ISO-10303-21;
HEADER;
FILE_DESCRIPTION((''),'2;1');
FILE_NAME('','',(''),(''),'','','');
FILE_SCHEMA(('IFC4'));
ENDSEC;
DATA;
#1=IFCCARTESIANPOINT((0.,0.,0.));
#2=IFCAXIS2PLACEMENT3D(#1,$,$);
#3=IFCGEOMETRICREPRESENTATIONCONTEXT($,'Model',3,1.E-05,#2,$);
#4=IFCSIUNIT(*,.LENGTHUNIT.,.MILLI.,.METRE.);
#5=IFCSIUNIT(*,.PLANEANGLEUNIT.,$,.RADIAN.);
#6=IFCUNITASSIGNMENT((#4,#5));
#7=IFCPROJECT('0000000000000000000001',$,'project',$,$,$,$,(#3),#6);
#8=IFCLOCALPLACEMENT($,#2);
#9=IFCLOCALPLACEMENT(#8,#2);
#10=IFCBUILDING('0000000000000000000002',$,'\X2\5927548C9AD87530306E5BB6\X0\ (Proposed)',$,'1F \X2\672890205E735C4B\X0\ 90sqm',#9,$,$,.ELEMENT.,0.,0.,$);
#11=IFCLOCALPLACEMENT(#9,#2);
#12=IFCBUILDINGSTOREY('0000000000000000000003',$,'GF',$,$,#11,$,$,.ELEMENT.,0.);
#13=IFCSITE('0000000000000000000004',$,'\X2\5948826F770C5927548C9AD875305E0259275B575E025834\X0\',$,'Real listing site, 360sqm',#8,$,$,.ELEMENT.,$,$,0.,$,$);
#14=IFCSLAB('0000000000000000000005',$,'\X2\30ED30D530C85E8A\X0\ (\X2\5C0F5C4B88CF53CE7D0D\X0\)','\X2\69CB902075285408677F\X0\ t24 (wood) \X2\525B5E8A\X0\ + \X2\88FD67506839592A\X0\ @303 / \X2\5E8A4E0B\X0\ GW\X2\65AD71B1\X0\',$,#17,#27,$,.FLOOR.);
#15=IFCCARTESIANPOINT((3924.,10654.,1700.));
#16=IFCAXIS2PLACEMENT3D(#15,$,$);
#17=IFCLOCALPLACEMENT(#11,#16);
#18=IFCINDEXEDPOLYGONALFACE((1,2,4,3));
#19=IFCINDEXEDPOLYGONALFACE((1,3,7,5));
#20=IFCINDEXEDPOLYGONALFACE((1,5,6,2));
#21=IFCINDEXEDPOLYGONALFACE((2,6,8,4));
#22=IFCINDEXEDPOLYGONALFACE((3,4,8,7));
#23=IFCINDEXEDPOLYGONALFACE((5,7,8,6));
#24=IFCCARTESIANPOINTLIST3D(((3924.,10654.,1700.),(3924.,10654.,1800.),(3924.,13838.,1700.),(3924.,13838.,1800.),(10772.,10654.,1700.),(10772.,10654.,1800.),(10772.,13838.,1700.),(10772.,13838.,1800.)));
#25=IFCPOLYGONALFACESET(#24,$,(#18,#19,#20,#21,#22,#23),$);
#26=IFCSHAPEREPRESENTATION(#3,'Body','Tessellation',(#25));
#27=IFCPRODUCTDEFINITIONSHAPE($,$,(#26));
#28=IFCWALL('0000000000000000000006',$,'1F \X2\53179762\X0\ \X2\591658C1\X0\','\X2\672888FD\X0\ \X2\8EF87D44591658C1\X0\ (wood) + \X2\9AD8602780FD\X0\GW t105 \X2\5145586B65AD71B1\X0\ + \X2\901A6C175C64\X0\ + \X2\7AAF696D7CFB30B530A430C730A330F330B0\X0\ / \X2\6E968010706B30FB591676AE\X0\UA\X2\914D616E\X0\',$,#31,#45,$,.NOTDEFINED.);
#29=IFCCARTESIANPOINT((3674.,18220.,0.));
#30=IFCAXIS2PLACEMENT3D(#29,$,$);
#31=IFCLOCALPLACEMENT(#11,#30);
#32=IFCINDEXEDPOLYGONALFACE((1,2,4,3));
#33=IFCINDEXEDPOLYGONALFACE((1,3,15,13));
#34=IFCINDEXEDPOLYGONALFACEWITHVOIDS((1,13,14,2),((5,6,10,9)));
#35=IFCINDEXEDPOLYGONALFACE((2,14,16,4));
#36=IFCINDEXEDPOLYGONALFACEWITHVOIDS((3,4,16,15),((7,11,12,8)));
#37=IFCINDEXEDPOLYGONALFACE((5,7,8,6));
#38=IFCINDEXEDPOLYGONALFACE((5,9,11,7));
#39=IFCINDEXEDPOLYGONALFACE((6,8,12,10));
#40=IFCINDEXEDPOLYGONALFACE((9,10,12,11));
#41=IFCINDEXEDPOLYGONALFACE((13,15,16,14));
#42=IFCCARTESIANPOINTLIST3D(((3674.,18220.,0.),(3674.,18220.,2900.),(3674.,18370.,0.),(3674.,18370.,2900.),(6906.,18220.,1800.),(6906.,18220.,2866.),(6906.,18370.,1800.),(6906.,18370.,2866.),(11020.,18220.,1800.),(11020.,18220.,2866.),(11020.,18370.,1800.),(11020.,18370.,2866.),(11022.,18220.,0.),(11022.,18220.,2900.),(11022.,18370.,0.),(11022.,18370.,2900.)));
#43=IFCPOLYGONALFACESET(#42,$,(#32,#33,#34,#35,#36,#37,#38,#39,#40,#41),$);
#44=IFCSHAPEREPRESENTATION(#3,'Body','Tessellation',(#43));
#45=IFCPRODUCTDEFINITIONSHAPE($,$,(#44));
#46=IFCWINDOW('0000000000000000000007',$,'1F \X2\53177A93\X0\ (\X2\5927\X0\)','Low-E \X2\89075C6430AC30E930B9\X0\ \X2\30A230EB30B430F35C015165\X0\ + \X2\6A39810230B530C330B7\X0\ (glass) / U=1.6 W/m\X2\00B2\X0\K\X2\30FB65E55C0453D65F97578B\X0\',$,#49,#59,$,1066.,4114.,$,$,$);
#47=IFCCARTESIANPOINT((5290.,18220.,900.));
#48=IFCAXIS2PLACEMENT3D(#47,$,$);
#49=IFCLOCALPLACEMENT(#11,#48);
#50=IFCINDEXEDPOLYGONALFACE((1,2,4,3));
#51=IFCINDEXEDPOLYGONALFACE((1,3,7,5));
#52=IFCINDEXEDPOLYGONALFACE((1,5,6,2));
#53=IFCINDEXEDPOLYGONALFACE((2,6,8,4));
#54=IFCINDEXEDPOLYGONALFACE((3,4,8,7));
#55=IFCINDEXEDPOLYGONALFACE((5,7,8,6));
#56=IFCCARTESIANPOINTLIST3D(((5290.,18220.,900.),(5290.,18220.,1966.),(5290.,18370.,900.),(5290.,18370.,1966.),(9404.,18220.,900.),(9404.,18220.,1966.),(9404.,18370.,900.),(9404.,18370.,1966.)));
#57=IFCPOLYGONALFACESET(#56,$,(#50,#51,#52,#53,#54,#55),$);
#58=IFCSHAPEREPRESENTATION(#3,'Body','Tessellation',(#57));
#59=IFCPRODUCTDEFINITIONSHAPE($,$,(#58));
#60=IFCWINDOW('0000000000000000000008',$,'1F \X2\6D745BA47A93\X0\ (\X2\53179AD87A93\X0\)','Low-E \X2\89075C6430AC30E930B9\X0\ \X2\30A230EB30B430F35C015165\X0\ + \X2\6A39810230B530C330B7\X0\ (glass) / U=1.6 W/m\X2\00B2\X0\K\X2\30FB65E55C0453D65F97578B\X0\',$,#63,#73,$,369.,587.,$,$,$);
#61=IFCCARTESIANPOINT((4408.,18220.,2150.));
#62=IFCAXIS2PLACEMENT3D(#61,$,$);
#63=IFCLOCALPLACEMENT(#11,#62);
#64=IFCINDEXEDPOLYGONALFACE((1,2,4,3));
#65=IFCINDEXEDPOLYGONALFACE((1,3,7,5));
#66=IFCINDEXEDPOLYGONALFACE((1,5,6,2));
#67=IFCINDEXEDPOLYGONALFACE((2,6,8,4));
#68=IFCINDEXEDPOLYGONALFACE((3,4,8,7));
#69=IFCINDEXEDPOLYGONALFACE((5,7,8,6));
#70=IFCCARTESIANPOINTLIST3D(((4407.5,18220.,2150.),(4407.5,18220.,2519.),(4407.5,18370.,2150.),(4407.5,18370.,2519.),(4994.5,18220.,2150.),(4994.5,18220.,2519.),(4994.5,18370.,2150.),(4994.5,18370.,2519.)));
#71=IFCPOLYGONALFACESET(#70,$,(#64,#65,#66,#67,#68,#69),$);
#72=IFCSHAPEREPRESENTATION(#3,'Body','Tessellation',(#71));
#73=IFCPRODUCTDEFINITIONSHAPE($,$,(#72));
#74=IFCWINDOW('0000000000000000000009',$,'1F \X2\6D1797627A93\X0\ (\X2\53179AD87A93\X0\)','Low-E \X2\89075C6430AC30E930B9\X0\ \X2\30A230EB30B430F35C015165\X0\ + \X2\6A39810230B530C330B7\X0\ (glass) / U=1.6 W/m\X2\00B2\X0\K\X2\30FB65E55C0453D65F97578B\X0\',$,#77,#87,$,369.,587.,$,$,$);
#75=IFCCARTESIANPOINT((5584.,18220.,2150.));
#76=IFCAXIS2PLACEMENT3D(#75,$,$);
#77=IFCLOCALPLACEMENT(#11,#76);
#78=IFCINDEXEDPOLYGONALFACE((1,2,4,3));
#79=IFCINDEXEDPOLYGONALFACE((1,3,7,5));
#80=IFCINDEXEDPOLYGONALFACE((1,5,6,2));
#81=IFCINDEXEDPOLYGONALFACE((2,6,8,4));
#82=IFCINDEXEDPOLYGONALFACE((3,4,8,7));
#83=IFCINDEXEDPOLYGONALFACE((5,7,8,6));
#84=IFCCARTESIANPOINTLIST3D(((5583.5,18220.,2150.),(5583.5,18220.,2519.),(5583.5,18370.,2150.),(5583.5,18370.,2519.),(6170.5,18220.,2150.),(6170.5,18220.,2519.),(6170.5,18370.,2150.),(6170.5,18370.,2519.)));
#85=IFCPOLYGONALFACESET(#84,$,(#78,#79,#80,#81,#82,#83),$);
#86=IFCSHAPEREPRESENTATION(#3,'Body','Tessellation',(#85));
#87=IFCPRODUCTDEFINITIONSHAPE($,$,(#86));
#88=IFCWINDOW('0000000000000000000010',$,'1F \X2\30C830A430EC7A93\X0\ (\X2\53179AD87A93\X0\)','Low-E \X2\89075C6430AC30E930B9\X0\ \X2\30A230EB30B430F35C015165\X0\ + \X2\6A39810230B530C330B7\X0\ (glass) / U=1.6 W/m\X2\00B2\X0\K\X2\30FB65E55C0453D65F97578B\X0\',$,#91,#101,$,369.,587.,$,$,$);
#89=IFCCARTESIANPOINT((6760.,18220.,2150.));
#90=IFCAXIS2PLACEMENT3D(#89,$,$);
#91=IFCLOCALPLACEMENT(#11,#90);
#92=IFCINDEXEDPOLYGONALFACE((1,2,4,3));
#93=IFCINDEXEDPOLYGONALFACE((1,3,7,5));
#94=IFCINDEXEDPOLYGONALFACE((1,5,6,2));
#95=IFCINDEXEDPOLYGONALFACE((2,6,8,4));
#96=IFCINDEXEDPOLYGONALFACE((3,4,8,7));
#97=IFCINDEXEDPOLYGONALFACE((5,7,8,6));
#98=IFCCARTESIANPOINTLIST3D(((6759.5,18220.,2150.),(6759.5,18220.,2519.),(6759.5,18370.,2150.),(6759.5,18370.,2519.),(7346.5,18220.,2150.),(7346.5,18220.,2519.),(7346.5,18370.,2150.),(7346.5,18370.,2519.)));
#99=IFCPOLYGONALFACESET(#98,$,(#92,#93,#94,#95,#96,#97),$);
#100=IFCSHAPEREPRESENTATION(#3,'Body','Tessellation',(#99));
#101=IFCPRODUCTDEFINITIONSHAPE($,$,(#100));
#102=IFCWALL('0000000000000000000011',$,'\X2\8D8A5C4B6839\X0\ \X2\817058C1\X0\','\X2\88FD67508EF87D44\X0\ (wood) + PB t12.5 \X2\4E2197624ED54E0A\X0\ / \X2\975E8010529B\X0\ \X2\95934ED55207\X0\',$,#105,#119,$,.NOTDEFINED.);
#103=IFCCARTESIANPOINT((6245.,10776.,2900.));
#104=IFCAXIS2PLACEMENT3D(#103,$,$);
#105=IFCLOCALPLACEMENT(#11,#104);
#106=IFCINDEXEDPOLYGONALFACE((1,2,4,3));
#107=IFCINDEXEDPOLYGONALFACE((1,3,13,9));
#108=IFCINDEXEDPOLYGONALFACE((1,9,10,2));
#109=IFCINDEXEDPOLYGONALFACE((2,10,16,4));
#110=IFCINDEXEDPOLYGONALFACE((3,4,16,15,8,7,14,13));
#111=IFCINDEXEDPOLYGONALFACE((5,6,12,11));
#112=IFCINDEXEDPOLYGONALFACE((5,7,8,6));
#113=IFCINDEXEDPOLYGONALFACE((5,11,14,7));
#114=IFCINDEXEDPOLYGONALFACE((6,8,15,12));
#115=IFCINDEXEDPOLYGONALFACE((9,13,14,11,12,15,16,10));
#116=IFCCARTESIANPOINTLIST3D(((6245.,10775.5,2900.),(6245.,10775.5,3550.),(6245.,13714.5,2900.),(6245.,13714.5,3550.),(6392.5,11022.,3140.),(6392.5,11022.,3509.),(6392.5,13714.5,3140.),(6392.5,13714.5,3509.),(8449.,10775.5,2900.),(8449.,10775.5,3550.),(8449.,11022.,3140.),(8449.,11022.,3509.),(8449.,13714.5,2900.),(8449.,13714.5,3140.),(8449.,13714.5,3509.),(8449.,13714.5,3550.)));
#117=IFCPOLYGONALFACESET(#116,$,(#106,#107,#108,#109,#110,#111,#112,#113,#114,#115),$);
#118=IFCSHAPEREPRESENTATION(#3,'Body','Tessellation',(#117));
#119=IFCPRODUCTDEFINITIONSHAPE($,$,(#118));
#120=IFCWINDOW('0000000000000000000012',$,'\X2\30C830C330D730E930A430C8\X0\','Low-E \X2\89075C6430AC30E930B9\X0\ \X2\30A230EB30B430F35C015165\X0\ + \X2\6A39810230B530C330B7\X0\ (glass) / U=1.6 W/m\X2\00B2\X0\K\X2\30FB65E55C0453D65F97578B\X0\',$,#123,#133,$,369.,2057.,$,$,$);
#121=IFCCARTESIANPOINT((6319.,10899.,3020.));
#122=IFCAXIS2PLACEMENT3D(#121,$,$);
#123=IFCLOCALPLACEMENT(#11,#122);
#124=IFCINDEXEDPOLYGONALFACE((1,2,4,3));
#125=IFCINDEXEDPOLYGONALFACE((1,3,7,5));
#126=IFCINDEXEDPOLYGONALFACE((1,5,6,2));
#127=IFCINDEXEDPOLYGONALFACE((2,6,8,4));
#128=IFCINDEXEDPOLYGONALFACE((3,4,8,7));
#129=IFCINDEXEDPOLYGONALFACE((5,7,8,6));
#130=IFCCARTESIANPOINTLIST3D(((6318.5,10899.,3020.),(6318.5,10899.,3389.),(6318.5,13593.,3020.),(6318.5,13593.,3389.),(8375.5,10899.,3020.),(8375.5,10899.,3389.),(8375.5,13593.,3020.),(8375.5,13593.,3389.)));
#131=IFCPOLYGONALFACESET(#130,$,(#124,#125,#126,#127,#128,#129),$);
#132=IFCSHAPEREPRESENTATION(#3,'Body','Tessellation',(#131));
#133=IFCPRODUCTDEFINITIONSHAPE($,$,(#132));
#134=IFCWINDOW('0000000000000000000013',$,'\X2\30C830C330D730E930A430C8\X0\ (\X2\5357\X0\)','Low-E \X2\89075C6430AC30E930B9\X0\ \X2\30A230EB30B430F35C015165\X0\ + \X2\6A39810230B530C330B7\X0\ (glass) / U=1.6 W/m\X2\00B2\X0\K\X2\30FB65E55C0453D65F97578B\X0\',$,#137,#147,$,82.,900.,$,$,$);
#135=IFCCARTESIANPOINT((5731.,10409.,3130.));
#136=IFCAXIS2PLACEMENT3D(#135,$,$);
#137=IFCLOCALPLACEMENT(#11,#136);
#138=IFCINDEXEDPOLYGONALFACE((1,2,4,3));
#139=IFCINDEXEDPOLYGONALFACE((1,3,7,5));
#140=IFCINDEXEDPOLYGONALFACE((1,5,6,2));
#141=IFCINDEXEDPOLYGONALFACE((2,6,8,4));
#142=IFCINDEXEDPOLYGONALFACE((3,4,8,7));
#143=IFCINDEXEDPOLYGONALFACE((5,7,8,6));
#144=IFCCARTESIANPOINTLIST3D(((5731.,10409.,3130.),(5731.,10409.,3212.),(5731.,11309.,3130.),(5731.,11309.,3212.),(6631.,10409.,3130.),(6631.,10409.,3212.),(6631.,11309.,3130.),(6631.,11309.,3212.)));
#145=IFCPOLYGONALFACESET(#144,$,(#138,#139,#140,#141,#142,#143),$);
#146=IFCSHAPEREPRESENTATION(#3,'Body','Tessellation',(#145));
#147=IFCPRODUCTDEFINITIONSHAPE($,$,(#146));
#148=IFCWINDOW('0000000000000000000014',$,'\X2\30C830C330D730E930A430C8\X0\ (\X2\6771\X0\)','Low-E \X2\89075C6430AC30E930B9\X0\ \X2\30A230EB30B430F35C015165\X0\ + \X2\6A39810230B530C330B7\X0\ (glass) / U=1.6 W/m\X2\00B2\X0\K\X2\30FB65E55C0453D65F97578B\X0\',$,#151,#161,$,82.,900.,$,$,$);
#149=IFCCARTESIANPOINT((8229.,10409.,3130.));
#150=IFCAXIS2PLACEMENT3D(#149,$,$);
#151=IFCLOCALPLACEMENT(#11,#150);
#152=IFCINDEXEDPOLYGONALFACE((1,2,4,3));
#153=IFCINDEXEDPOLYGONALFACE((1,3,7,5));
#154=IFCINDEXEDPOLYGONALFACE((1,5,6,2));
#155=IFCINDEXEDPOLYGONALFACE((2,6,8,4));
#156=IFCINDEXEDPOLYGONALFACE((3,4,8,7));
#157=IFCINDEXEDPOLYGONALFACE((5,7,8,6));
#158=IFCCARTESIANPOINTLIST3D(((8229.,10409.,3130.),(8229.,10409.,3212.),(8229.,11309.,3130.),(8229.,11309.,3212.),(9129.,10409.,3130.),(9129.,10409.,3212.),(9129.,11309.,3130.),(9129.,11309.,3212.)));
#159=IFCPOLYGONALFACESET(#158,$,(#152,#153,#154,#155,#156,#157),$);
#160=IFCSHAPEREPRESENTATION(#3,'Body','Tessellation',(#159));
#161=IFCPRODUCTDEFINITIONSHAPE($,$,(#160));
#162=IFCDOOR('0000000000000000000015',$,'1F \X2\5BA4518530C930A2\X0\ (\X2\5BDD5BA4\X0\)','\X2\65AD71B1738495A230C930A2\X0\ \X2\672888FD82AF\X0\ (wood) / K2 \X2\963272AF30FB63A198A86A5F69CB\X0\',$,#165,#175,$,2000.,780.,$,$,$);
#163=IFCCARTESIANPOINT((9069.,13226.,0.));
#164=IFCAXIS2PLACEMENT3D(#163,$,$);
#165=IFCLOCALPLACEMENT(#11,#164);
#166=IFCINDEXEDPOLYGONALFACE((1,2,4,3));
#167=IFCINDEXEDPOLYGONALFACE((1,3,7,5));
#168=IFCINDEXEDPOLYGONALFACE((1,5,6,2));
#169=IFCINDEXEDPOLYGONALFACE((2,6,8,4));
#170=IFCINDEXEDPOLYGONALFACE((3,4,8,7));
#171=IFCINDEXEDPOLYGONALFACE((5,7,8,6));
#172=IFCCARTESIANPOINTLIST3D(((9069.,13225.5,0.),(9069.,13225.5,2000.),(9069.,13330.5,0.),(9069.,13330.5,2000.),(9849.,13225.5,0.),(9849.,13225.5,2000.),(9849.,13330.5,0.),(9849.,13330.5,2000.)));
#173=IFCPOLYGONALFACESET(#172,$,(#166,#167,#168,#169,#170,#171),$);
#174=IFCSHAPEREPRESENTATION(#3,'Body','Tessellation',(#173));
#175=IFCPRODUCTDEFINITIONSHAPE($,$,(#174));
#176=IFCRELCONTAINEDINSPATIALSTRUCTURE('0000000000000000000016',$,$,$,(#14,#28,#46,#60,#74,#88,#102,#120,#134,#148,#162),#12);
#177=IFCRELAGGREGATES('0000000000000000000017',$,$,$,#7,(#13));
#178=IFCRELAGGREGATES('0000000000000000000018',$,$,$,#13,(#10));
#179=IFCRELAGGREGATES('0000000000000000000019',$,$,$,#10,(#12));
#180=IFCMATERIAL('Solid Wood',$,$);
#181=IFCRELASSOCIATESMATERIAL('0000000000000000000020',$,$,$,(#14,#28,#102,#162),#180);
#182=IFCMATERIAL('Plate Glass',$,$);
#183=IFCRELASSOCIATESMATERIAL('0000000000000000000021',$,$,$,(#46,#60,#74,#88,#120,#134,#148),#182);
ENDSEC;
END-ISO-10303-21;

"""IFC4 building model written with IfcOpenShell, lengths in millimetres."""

from ifc_helpers import new_model, si_unit, frame, frame_2d, origin, place, context, project, spatial, rectangle, extrude, material, element, fill, save


model = new_model("IFC4")

# Units and contexts
model_context = context("Model", 3, precision=1e-05, world=origin())
ifc_project = project(units=[si_unit("LENGTHUNIT", "METRE", prefix="MILLI"), si_unit("PLANEANGLEUNIT", "RADIAN")], contexts=[model_context])

# Site, building, storey
site_placement = place(None, origin())
site = spatial("IfcSite", under=ifc_project, at=site_placement, Name="奈良県大和高田市大字市場", ObjectType="Real listing site, 360sqm", CompositionType="ELEMENT", RefElevation=0.0)
building_placement = place(site_placement, origin())
building = spatial("IfcBuilding", under=site, at=building_placement, Name="大和高田の家 (Proposed)", ObjectType="1F 木造平屋 90sqm", CompositionType="ELEMENT", ElevationOfRefHeight=0.0, ElevationOfTerrain=0.0)
storey_placement = place(building_placement, origin())
storey = spatial("IfcBuildingStorey", under=building, at=storey_placement, Name="GF", CompositionType="ELEMENT", Elevation=0.0)

# Slab
ifc_material_1 = material(Name="Solid Wood")
slab_placement = place(storey_placement, frame((3924.0, 10654.0, 1700.0)))
element("IfcSlab", 1, at=slab_placement, inside=storey, material=ifc_material_1, Name="ロフト床 (小屋裏収納)", Description="構造用合板 t24 (wood) 剛床 + 製材根太 @303 / 床下 GW断熱", PredefinedType="FLOOR", context=model_context, shape_type="SweptSolid", body=[
    extrude(rectangle(XDim=6848.0, YDim=3184.0, at=frame_2d((3424.0, 1592.0))), frame((3924.0, 10654.0, 1700.0)), (0.0, 0.0, 1.0), 100.0),
])

# Wall, openings, windows
wall_1_placement = place(storey_placement, frame((3674.0, 18220.0, 0.0)))
wall_1 = element("IfcWall", 2, at=wall_1_placement, inside=storey, material=ifc_material_1, Name="1F 北面 外壁", Description="木製 軸組外壁 (wood) + 高性能GW t105 充填断熱 + 通気層 + 窯業系サイディング / 準耐火・外皮UA配慮", PredefinedType="NOTDEFINED", context=model_context, shape_type="SweptSolid", body=[
    extrude(rectangle(XDim=7348.0, YDim=150.0, at=frame_2d((3674.0, 75.0))), frame((3674.0, 18220.0, 0.0)), (0.0, 0.0, 1.0), 2900.0),
])
opening_1_placement = place(storey_placement, frame((5290.0, 18220.0, 900.0)))
opening_1 = element("IfcOpeningElement", 3, at=opening_1_placement, cuts=wall_1, PredefinedType="NOTDEFINED", context=model_context, shape_type="SweptSolid", body=[
    extrude(rectangle(XDim=4114.0, YDim=150.0, at=frame_2d((2057.0, 75.0))), frame((5290.0, 18220.0, 900.0)), (0.0, 0.0, 1.0), 1066.0),
])
opening_2_placement = place(storey_placement, frame((4408.0, 18220.0, 2150.0)))
opening_2 = element("IfcOpeningElement", 4, at=opening_2_placement, cuts=wall_1, PredefinedType="NOTDEFINED", context=model_context, shape_type="SweptSolid", body=[
    extrude(rectangle(XDim=587.0, YDim=150.0, at=frame_2d((293.0, 75.0))), frame((4408.0, 18220.0, 2150.0)), (0.0, 0.0, 1.0), 369.0),
])
opening_3_placement = place(storey_placement, frame((5584.0, 18220.0, 2150.0)))
opening_3 = element("IfcOpeningElement", 5, at=opening_3_placement, cuts=wall_1, PredefinedType="NOTDEFINED", context=model_context, shape_type="SweptSolid", body=[
    extrude(rectangle(XDim=587.0, YDim=150.0, at=frame_2d((293.0, 75.0))), frame((5584.0, 18220.0, 2150.0)), (0.0, 0.0, 1.0), 369.0),
])
opening_4_placement = place(storey_placement, frame((6760.0, 18220.0, 2150.0)))
opening_4 = element("IfcOpeningElement", 6, at=opening_4_placement, cuts=wall_1, PredefinedType="NOTDEFINED", context=model_context, shape_type="SweptSolid", body=[
    extrude(rectangle(XDim=587.0, YDim=150.0, at=frame_2d((293.0, 75.0))), frame((6760.0, 18220.0, 2150.0)), (0.0, 0.0, 1.0), 369.0),
])
ifc_material_2 = material(Name="Plate Glass")
window_1_placement = place(storey_placement, frame((5290.0, 18220.0, 900.0)))
window_1 = element("IfcWindow", 7, at=window_1_placement, inside=storey, material=ifc_material_2, Name="1F 北窓 (大)", Description="Low-E 複層ガラス アルゴン封入 + 樹脂サッシ (glass) / U=1.6 W/m²K・日射取得型", OverallHeight=1066.0, OverallWidth=4114.0, context=model_context, shape_type="SweptSolid", body=[
    extrude(rectangle(XDim=4114.0, YDim=150.0, at=frame_2d((2057.0, 75.0))), frame((5290.0, 18220.0, 900.0)), (0.0, 0.0, 1.0), 1066.0),
])
fill(opening_1, window_1)
window_2_placement = place(storey_placement, frame((4408.0, 18220.0, 2150.0)))
window_2 = element("IfcWindow", 8, at=window_2_placement, inside=storey, material=ifc_material_2, Name="1F 浴室窓 (北高窓)", Description="Low-E 複層ガラス アルゴン封入 + 樹脂サッシ (glass) / U=1.6 W/m²K・日射取得型", OverallHeight=369.0, OverallWidth=587.0, context=model_context, shape_type="SweptSolid", body=[
    extrude(rectangle(XDim=587.0, YDim=150.0, at=frame_2d((293.0, 75.0))), frame((4408.0, 18220.0, 2150.0)), (0.0, 0.0, 1.0), 369.0),
])
fill(opening_2, window_2)
window_3_placement = place(storey_placement, frame((5584.0, 18220.0, 2150.0)))
window_3 = element("IfcWindow", 9, at=window_3_placement, inside=storey, material=ifc_material_2, Name="1F 洗面窓 (北高窓)", Description="Low-E 複層ガラス アルゴン封入 + 樹脂サッシ (glass) / U=1.6 W/m²K・日射取得型", OverallHeight=369.0, OverallWidth=587.0, context=model_context, shape_type="SweptSolid", body=[
    extrude(rectangle(XDim=587.0, YDim=150.0, at=frame_2d((293.0, 75.0))), frame((5584.0, 18220.0, 2150.0)), (0.0, 0.0, 1.0), 369.0),
])
fill(opening_3, window_3)
window_4_placement = place(storey_placement, frame((6760.0, 18220.0, 2150.0)))
window_4 = element("IfcWindow", 10, at=window_4_placement, inside=storey, material=ifc_material_2, Name="1F トイレ窓 (北高窓)", Description="Low-E 複層ガラス アルゴン封入 + 樹脂サッシ (glass) / U=1.6 W/m²K・日射取得型", OverallHeight=369.0, OverallWidth=587.0, context=model_context, shape_type="SweptSolid", body=[
    extrude(rectangle(XDim=587.0, YDim=150.0, at=frame_2d((293.0, 75.0))), frame((6760.0, 18220.0, 2150.0)), (0.0, 0.0, 1.0), 369.0),
])
fill(opening_4, window_4)

# Wall, openings, windows
wall_2_placement = place(storey_placement, frame((6245.0, 10776.0, 2900.0)))
wall_2 = element("IfcWall", 11, at=wall_2_placement, inside=storey, material=ifc_material_1, Name="越屋根 腰壁", Description="製材軸組 (wood) + PB t12.5 両面仕上 / 非耐力 間仕切", PredefinedType="NOTDEFINED", context=model_context, shape_type="SweptSolid", body=[
    extrude(rectangle(XDim=2204.0, YDim=2939.0, at=frame_2d((1102.0, 1469.0))), frame((6245.0, 10776.0, 2900.0)), (0.0, 0.0, 1.0), 650.0),
])
opening_5_placement = place(storey_placement, frame((6319.0, 10899.0, 3020.0)))
opening_5 = element("IfcOpeningElement", 12, at=opening_5_placement, cuts=wall_2, PredefinedType="NOTDEFINED", context=model_context, shape_type="SweptSolid", body=[
    extrude(rectangle(XDim=2057.0, YDim=2694.0, at=frame_2d((1028.0, 1347.0))), frame((6319.0, 10899.0, 3020.0)), (0.0, 0.0, 1.0), 369.0),
])
opening_6_placement = place(storey_placement, frame((5731.0, 10409.0, 3130.0)))
opening_6 = element("IfcOpeningElement", 13, at=opening_6_placement, cuts=wall_2, PredefinedType="NOTDEFINED", context=model_context, shape_type="SweptSolid", body=[
    extrude(rectangle(XDim=900.0, YDim=900.0, at=frame_2d((450.0, 450.0))), frame((5731.0, 10409.0, 3130.0)), (0.0, 0.0, 1.0), 82.0),
])
opening_7_placement = place(storey_placement, frame((8229.0, 10409.0, 3130.0)))
opening_7 = element("IfcOpeningElement", 14, at=opening_7_placement, cuts=wall_2, PredefinedType="NOTDEFINED", context=model_context, shape_type="SweptSolid", body=[
    extrude(rectangle(XDim=900.0, YDim=900.0, at=frame_2d((450.0, 450.0))), frame((8229.0, 10409.0, 3130.0)), (0.0, 0.0, 1.0), 82.0),
])
window_5_placement = place(storey_placement, frame((6319.0, 10899.0, 3020.0)))
window_5 = element("IfcWindow", 15, at=window_5_placement, inside=storey, material=ifc_material_2, Name="トップライト", Description="Low-E 複層ガラス アルゴン封入 + 樹脂サッシ (glass) / U=1.6 W/m²K・日射取得型", OverallHeight=369.0, OverallWidth=2057.0, context=model_context, shape_type="SweptSolid", body=[
    extrude(rectangle(XDim=2057.0, YDim=2694.0, at=frame_2d((1028.0, 1347.0))), frame((6319.0, 10899.0, 3020.0)), (0.0, 0.0, 1.0), 369.0),
])
fill(opening_5, window_5)
window_6_placement = place(storey_placement, frame((5731.0, 10409.0, 3130.0)))
window_6 = element("IfcWindow", 16, at=window_6_placement, inside=storey, material=ifc_material_2, Name="トップライト (南)", Description="Low-E 複層ガラス アルゴン封入 + 樹脂サッシ (glass) / U=1.6 W/m²K・日射取得型", OverallHeight=82.0, OverallWidth=900.0, context=model_context, shape_type="SweptSolid", body=[
    extrude(rectangle(XDim=900.0, YDim=900.0, at=frame_2d((450.0, 450.0))), frame((5731.0, 10409.0, 3130.0)), (0.0, 0.0, 1.0), 82.0),
])
fill(opening_6, window_6)
window_7_placement = place(storey_placement, frame((8229.0, 10409.0, 3130.0)))
window_7 = element("IfcWindow", 17, at=window_7_placement, inside=storey, material=ifc_material_2, Name="トップライト (東)", Description="Low-E 複層ガラス アルゴン封入 + 樹脂サッシ (glass) / U=1.6 W/m²K・日射取得型", OverallHeight=82.0, OverallWidth=900.0, context=model_context, shape_type="SweptSolid", body=[
    extrude(rectangle(XDim=900.0, YDim=900.0, at=frame_2d((450.0, 450.0))), frame((8229.0, 10409.0, 3130.0)), (0.0, 0.0, 1.0), 82.0),
])
fill(opening_7, window_7)

# Door
door_1_placement = place(storey_placement, frame((9069.0, 13226.0, 0.0)))
element("IfcDoor", 18, at=door_1_placement, inside=storey, material=ifc_material_1, Name="1F 室内ドア (寝室)", Description="断熱玄関ドア 木製芯 (wood) / K2 防犯・採風機構", OverallHeight=2000.0, OverallWidth=780.0, context=model_context, shape_type="SweptSolid", body=[
    extrude(rectangle(XDim=780.0, YDim=105.0, at=frame_2d((390.0, 52.0))), frame((9069.0, 13226.0, 0.0)), (0.0, 0.0, 1.0), 2000.0),
])

save(model, "model.ifc")
